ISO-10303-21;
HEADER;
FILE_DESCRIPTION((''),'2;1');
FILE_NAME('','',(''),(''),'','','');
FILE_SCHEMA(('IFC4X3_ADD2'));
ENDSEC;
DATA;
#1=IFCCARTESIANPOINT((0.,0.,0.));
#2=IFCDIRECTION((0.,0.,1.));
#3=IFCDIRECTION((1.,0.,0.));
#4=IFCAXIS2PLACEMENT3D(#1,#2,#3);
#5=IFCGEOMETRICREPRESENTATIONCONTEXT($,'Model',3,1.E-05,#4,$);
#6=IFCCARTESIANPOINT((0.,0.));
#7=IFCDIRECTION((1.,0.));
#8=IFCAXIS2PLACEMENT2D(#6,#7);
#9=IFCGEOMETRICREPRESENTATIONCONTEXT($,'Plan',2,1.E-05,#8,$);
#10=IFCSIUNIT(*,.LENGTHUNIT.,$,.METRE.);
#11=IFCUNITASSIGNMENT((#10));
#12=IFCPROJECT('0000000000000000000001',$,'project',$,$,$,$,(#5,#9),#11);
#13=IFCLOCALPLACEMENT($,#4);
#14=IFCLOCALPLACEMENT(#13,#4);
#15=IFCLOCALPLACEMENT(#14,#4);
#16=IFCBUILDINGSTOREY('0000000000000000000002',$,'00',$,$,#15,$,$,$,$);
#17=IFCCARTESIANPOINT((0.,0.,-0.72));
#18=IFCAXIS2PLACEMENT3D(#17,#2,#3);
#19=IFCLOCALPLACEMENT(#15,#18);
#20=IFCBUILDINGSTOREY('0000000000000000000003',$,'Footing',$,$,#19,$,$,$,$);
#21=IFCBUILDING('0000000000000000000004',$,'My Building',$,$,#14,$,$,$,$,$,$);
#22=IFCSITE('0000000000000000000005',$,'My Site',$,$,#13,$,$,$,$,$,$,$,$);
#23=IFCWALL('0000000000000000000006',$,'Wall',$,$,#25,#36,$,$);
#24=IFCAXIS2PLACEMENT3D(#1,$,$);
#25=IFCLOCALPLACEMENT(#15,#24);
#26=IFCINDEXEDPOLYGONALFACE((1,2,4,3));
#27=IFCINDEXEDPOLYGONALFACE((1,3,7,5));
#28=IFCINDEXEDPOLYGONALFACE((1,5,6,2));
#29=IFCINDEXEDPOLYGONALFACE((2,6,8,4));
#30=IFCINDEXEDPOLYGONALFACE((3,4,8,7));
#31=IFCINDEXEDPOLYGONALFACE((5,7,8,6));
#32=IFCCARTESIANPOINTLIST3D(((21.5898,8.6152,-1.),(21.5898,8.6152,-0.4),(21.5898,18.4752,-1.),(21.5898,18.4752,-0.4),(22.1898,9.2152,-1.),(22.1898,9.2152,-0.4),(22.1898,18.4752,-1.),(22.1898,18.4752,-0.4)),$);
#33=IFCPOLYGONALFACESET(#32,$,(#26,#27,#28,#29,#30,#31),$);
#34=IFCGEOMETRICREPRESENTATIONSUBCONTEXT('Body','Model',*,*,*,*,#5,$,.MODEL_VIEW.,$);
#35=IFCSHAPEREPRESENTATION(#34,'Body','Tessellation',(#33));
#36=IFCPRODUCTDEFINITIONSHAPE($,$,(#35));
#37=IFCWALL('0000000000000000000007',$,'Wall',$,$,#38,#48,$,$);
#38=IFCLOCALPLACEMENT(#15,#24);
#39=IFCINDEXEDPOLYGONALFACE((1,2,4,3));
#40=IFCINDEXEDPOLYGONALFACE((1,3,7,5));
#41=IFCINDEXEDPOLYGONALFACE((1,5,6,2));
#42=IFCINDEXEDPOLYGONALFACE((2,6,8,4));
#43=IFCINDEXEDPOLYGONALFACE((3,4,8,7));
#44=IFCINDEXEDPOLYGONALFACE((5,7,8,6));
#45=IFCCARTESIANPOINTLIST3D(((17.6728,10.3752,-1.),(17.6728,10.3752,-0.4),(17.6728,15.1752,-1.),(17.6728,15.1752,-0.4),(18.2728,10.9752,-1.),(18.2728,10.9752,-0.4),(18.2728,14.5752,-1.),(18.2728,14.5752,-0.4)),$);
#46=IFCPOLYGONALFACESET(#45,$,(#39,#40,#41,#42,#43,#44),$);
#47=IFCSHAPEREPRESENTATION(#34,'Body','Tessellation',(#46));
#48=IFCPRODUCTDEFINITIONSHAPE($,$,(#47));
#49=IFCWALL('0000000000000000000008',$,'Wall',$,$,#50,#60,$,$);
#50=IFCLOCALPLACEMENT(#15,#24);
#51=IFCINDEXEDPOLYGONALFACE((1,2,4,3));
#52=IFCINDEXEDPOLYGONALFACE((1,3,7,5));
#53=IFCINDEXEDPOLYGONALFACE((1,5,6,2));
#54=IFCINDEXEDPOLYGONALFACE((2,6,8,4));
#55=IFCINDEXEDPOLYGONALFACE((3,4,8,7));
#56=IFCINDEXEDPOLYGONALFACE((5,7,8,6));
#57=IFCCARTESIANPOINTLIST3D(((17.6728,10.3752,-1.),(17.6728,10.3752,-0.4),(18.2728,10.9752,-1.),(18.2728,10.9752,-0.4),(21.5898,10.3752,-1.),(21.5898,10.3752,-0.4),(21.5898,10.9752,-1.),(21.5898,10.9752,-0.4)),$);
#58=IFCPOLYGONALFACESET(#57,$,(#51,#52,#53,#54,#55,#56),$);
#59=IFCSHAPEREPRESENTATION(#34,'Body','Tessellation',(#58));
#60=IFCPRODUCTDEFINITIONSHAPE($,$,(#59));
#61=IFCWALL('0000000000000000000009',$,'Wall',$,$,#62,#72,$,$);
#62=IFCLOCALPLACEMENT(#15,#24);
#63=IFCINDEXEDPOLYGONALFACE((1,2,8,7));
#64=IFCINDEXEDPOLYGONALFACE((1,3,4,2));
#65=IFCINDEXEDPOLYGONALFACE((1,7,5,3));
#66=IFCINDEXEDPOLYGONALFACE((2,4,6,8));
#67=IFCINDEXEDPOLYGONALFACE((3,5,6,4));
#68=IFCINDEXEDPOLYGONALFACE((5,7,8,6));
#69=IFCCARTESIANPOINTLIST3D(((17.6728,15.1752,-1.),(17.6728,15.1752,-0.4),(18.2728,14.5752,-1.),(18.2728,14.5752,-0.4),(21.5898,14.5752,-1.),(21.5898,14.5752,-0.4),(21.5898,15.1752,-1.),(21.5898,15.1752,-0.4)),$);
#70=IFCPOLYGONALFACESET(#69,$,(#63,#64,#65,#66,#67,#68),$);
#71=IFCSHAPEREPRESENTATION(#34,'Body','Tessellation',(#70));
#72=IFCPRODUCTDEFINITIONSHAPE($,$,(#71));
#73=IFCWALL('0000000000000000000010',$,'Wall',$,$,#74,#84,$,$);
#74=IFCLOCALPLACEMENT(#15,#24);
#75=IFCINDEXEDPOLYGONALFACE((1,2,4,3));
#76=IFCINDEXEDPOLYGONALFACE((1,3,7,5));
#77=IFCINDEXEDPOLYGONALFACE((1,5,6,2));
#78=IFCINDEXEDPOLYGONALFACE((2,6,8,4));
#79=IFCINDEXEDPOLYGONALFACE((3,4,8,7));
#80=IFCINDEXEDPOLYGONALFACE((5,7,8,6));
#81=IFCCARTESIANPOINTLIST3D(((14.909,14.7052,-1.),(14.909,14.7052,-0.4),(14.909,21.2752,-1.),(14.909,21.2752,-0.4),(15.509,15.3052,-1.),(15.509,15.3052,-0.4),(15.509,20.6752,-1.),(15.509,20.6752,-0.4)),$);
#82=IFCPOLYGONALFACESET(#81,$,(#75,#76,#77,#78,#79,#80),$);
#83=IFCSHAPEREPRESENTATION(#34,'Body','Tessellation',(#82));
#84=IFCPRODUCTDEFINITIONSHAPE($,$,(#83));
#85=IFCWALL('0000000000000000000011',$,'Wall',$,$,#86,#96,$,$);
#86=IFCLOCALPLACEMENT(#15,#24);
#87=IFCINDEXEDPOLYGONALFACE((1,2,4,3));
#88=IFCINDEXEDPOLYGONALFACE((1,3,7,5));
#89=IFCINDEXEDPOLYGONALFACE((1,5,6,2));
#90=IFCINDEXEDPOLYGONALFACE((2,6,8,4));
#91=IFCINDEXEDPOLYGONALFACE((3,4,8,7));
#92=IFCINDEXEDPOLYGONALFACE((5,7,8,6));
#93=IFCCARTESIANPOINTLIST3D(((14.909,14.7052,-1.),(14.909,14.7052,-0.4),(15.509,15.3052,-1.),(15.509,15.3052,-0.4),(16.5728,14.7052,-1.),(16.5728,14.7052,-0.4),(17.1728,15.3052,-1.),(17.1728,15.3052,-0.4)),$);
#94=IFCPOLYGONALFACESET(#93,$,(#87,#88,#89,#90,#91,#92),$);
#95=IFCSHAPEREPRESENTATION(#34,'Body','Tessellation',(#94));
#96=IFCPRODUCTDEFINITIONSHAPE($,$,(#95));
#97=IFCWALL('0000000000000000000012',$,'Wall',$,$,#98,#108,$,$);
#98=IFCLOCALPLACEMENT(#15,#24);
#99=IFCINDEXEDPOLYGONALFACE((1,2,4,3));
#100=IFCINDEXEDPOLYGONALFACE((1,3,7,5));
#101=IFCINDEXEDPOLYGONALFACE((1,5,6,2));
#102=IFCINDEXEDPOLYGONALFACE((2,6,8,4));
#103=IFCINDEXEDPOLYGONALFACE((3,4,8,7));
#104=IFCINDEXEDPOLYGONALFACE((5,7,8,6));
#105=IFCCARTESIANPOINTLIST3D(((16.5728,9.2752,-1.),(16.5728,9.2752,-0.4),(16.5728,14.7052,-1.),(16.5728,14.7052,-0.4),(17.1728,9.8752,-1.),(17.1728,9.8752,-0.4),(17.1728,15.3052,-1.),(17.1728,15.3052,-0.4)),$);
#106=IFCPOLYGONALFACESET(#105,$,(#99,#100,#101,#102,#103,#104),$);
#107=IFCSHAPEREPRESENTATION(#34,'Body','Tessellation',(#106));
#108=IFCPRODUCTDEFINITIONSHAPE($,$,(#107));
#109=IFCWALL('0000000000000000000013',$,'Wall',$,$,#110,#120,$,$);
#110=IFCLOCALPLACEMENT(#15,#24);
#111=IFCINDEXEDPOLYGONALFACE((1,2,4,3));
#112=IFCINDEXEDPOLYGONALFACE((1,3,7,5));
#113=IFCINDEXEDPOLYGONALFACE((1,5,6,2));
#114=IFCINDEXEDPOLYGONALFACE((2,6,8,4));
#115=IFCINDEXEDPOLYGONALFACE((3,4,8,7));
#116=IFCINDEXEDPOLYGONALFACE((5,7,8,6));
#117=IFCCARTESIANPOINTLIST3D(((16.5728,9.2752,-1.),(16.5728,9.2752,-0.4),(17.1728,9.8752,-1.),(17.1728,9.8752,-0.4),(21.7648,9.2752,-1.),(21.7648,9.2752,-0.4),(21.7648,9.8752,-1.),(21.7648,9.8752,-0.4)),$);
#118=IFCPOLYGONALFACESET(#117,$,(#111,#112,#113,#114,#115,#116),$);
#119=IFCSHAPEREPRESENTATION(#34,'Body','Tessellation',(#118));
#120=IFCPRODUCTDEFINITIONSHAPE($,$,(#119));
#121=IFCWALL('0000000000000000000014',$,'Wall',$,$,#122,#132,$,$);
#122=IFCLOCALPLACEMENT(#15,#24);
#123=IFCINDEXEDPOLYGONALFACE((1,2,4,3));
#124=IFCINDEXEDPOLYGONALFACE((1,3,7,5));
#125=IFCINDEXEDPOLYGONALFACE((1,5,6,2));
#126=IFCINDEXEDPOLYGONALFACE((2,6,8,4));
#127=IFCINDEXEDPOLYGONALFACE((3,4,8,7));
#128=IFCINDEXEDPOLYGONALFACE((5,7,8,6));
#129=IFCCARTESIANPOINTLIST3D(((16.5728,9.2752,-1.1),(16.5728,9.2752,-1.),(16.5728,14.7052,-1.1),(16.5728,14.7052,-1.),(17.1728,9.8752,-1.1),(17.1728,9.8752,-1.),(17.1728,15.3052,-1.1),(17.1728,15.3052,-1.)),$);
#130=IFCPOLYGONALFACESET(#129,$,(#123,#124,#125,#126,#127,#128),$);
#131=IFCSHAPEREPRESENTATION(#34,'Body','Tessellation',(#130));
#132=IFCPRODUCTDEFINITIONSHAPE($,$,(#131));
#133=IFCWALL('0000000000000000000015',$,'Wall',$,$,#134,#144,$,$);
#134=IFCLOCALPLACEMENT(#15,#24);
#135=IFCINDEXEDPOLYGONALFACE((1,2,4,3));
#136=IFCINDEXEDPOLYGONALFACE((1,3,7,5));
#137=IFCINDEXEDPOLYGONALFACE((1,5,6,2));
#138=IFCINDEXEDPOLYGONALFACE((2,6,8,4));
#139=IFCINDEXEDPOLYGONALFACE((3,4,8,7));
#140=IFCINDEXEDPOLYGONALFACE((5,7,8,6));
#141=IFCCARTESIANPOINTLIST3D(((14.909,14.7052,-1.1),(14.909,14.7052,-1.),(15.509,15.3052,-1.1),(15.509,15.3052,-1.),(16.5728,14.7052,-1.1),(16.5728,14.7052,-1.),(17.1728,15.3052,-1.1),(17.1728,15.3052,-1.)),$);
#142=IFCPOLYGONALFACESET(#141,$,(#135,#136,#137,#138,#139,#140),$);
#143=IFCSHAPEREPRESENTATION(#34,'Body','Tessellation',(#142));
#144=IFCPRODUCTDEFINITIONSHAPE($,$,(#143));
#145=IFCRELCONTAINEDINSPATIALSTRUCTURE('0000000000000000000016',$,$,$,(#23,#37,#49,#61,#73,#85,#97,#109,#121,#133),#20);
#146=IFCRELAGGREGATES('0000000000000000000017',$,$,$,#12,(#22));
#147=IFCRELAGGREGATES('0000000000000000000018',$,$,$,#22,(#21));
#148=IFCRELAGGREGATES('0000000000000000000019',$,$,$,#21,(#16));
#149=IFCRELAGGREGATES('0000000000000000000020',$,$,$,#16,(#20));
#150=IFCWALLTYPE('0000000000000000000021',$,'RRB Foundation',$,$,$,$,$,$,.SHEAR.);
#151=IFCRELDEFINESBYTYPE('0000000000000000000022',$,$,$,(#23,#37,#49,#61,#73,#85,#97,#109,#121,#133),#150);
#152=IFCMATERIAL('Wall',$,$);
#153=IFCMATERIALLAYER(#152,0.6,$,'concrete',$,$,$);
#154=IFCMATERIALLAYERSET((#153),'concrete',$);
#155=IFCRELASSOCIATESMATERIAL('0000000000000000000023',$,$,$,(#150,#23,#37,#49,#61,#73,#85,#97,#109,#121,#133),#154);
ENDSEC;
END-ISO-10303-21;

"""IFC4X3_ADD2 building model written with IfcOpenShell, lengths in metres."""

from ifc_helpers import new_model, si_unit, frame, origin_with_axes, origin_2d_with_axis, place, context, subcontext, project, spatial, line, indexed_curve, outline, extrude, material, layer, layer_set, layer_usage, type_object, element, save


model = new_model("IFC4X3_ADD2")

# Units and contexts
model_context = context("Model", 3, precision=1e-05, world=origin_with_axes())
plan_context = context("Plan", 2, precision=1e-05, world=origin_2d_with_axis())
body_context = subcontext(model_context, "Body", "Model", "MODEL_VIEW")
ifc_project = project(units=[si_unit("LENGTHUNIT", "METRE")], contexts=[model_context, plan_context])

# Site, building, storeys
site_placement = place(None, origin_with_axes())
site = spatial("IfcSite", under=ifc_project, at=site_placement, Name="My Site")
building_placement = place(site_placement, origin_with_axes())
building = spatial("IfcBuilding", under=site, at=building_placement, Name="My Building")
storey_1_placement = place(building_placement, origin_with_axes())
storey_1 = spatial("IfcBuildingStorey", under=building, at=storey_1_placement, Name="00")
storey_2_placement = place(storey_1_placement, frame((0.0, 0.0, -0.72), z_axis=(0.0, 0.0, 1.0), x_axis=(1.0, 0.0, 0.0)))
storey_2 = spatial("IfcBuildingStorey", under=storey_1, at=storey_2_placement, Name="Footing")

# Walls
ifc_material_1 = material(Name="Wall")
ifc_layer_1 = layer(ifc_material_1, 0.6, Name="concrete")
ifc_layer_set_1 = layer_set([ifc_layer_1], Name="concrete")
wall_type_1 = type_object("IfcWallType", Name="RRB Foundation", PredefinedType="SHEAR", material=ifc_layer_set_1)
ifc_layer_usage_1 = layer_usage(ifc_layer_set_1, "AXIS2", "POSITIVE", 0.0)
wall_1_placement = place(storey_2_placement, frame((22.1898, 8.6152, -0.28), z_axis=(0.0, 0.0, 1.0), x_axis=(0.000001, 1.0, 0.0)))
element("IfcWall", 1, at=wall_1_placement, inside=storey_2, type_object=wall_type_1, material=ifc_layer_usage_1, Name="Wall", context=body_context, shape_type="SweptSolid", body=[
    extrude(outline(indexed_curve([(0.6, 0.0), (0.0, 0.6), (9.86, 0.6), (9.86, 0.0)], segments=[line(1, 2, 3, 4, 1)])), origin_with_axes(), (0.0, 0.0, 1.0), 0.6),
])
ifc_layer_usage_2 = layer_usage(ifc_layer_set_1, "AXIS2", "POSITIVE", 0.0)
wall_2_placement = place(storey_2_placement, frame((18.2728, 10.3752, -0.28), z_axis=(0.0, 0.0, 1.0), x_axis=(0.000001, 1.0, 0.0)))
element("IfcWall", 2, at=wall_2_placement, inside=storey_2, type_object=wall_type_1, material=ifc_layer_usage_2, Name="Wall", context=body_context, shape_type="SweptSolid", body=[
    extrude(outline(indexed_curve([(0.6, 0.0), (0.0, 0.6), (4.8, 0.6), (4.2, 0.0)], segments=[line(1, 2, 3, 4, 1)])), origin_with_axes(), (0.0, 0.0, 1.0), 0.6),
])
ifc_layer_usage_3 = layer_usage(ifc_layer_set_1, "AXIS2", "POSITIVE", 0.0)
wall_3_placement = place(storey_2_placement, frame((18.2728, 10.3752, -0.28), z_axis=(0.0, 0.0, 1.0), x_axis=(1.0, 0.0, 0.0)))
element("IfcWall", 3, at=wall_3_placement, inside=storey_2, type_object=wall_type_1, material=ifc_layer_usage_3, Name="Wall", context=body_context, shape_type="SweptSolid", body=[
    extrude(outline(indexed_curve([(-0.6, 0.0), (0.0, 0.6), (3.317, 0.6), (3.317, 0.0)], segments=[line(1, 2, 3, 4, 1)])), origin_with_axes(), (0.0, 0.0, 1.0), 0.6),
])
ifc_layer_usage_4 = layer_usage(ifc_layer_set_1, "AXIS2", "POSITIVE", 0.0)
wall_4_placement = place(storey_2_placement, frame((18.2728, 14.5752, -0.28), z_axis=(0.0, 0.0, 1.0), x_axis=(1.0, 0.0, 0.0)))
element("IfcWall", 4, at=wall_4_placement, inside=storey_2, type_object=wall_type_1, material=ifc_layer_usage_4, Name="Wall", context=body_context, shape_type="SweptSolid", body=[
    extrude(outline(indexed_curve([(0.0, 0.0), (-0.6, 0.6), (3.317, 0.6), (3.317, 0.0)], segments=[line(1, 2, 3, 4, 1)])), origin_with_axes(), (0.0, 0.0, 1.0), 0.6),
])
ifc_layer_usage_5 = layer_usage(ifc_layer_set_1, "AXIS2", "POSITIVE", 0.0)
wall_5_placement = place(storey_2_placement, frame((15.509, 14.7052, -0.28), z_axis=(0.0, 0.0, 1.0), x_axis=(0.000001, 1.0, 0.0)))
element("IfcWall", 5, at=wall_5_placement, inside=storey_2, type_object=wall_type_1, material=ifc_layer_usage_5, Name="Wall", context=body_context, shape_type="SweptSolid", body=[
    extrude(outline(indexed_curve([(0.6, 0.0), (0.0, 0.6), (6.57, 0.6), (5.97, 0.0)], segments=[line(1, 2, 3, 4, 1)])), origin_with_axes(), (0.0, 0.0, 1.0), 0.6),
])
ifc_layer_usage_6 = layer_usage(ifc_layer_set_1, "AXIS2", "POSITIVE", 0.0)
wall_6_placement = place(storey_2_placement, frame((15.509, 14.7052, -0.28), z_axis=(0.0, 0.0, 1.0), x_axis=(1.0, 0.0, 0.0)))
element("IfcWall", 6, at=wall_6_placement, inside=storey_2, type_object=wall_type_1, material=ifc_layer_usage_6, Name="Wall", context=body_context, shape_type="SweptSolid", body=[
    extrude(outline(indexed_curve([(-0.6, 0.0), (0.0, 0.6), (1.6638, 0.6), (1.0638, 0.0)], segments=[line(1, 2, 3, 4, 1)])), origin_with_axes(), (0.0, 0.0, 1.0), 0.6),
])
ifc_layer_usage_7 = layer_usage(ifc_layer_set_1, "AXIS2", "POSITIVE", 0.0)
wall_7_placement = place(storey_2_placement, frame((17.1728, 9.2752, -0.28), z_axis=(0.0, 0.0, 1.0), x_axis=(0.000001, 1.0, 0.0)))
element("IfcWall", 7, at=wall_7_placement, inside=storey_2, type_object=wall_type_1, material=ifc_layer_usage_7, Name="Wall", context=body_context, shape_type="SweptSolid", body=[
    extrude(outline(indexed_curve([(0.6, 0.0), (0.0, 0.6), (5.43, 0.6), (6.03, 0.0)], segments=[line(1, 2, 3, 4, 1)])), origin_with_axes(), (0.0, 0.0, 1.0), 0.6),
])
ifc_layer_usage_8 = layer_usage(ifc_layer_set_1, "AXIS2", "POSITIVE", 0.0)
wall_8_placement = place(storey_2_placement, frame((17.1728, 9.2752, -0.28), z_axis=(0.0, 0.0, 1.0), x_axis=(1.0, 0.0, 0.0)))
element("IfcWall", 8, at=wall_8_placement, inside=storey_2, type_object=wall_type_1, material=ifc_layer_usage_8, Name="Wall", context=body_context, shape_type="SweptSolid", body=[
    extrude(outline(indexed_curve([(-0.6, 0.0), (0.0, 0.6), (4.592, 0.6), (4.592, 0.0)], segments=[line(1, 2, 3, 4, 1)])), origin_with_axes(), (0.0, 0.0, 1.0), 0.6),
])
ifc_layer_usage_9 = layer_usage(ifc_layer_set_1, "AXIS2", "POSITIVE", 0.0)
wall_9_placement = place(storey_2_placement, frame((17.1728, 9.8752, -0.38), z_axis=(0.0, 0.0, 1.0), x_axis=(0.000001, 1.0, 0.0)))
element("IfcWall", 9, at=wall_9_placement, inside=storey_2, type_object=wall_type_1, material=ifc_layer_usage_9, Name="Wall", context=body_context, shape_type="SweptSolid", body=[
    extrude(outline(indexed_curve([(0.0, 0.0), (-0.6, 0.6), (4.83, 0.6), (5.43, 0.0)], segments=[line(1, 2, 3, 4, 1)])), origin_with_axes(), (0.0, 0.0, 1.0), 0.1),
])
ifc_layer_usage_10 = layer_usage(ifc_layer_set_1, "AXIS2", "POSITIVE", 0.0)
wall_10_placement = place(storey_2_placement, frame((17.1728, 15.3052, -0.38), z_axis=(0.0, 0.0, 1.0), x_axis=(-1.0, 0.000001, 0.0)))
element("IfcWall", 10, at=wall_10_placement, inside=storey_2, type_object=wall_type_1, material=ifc_layer_usage_10, Name="Wall", context=body_context, shape_type="SweptSolid", body=[
    extrude(outline(indexed_curve([(0.0, 0.0), (0.6, 0.6), (2.2638, 0.6), (1.6638, 0.0)], segments=[line(1, 2, 3, 4, 1)])), origin_with_axes(), (0.0, 0.0, 1.0), 0.1),
])

save(model, "model.ifc")
